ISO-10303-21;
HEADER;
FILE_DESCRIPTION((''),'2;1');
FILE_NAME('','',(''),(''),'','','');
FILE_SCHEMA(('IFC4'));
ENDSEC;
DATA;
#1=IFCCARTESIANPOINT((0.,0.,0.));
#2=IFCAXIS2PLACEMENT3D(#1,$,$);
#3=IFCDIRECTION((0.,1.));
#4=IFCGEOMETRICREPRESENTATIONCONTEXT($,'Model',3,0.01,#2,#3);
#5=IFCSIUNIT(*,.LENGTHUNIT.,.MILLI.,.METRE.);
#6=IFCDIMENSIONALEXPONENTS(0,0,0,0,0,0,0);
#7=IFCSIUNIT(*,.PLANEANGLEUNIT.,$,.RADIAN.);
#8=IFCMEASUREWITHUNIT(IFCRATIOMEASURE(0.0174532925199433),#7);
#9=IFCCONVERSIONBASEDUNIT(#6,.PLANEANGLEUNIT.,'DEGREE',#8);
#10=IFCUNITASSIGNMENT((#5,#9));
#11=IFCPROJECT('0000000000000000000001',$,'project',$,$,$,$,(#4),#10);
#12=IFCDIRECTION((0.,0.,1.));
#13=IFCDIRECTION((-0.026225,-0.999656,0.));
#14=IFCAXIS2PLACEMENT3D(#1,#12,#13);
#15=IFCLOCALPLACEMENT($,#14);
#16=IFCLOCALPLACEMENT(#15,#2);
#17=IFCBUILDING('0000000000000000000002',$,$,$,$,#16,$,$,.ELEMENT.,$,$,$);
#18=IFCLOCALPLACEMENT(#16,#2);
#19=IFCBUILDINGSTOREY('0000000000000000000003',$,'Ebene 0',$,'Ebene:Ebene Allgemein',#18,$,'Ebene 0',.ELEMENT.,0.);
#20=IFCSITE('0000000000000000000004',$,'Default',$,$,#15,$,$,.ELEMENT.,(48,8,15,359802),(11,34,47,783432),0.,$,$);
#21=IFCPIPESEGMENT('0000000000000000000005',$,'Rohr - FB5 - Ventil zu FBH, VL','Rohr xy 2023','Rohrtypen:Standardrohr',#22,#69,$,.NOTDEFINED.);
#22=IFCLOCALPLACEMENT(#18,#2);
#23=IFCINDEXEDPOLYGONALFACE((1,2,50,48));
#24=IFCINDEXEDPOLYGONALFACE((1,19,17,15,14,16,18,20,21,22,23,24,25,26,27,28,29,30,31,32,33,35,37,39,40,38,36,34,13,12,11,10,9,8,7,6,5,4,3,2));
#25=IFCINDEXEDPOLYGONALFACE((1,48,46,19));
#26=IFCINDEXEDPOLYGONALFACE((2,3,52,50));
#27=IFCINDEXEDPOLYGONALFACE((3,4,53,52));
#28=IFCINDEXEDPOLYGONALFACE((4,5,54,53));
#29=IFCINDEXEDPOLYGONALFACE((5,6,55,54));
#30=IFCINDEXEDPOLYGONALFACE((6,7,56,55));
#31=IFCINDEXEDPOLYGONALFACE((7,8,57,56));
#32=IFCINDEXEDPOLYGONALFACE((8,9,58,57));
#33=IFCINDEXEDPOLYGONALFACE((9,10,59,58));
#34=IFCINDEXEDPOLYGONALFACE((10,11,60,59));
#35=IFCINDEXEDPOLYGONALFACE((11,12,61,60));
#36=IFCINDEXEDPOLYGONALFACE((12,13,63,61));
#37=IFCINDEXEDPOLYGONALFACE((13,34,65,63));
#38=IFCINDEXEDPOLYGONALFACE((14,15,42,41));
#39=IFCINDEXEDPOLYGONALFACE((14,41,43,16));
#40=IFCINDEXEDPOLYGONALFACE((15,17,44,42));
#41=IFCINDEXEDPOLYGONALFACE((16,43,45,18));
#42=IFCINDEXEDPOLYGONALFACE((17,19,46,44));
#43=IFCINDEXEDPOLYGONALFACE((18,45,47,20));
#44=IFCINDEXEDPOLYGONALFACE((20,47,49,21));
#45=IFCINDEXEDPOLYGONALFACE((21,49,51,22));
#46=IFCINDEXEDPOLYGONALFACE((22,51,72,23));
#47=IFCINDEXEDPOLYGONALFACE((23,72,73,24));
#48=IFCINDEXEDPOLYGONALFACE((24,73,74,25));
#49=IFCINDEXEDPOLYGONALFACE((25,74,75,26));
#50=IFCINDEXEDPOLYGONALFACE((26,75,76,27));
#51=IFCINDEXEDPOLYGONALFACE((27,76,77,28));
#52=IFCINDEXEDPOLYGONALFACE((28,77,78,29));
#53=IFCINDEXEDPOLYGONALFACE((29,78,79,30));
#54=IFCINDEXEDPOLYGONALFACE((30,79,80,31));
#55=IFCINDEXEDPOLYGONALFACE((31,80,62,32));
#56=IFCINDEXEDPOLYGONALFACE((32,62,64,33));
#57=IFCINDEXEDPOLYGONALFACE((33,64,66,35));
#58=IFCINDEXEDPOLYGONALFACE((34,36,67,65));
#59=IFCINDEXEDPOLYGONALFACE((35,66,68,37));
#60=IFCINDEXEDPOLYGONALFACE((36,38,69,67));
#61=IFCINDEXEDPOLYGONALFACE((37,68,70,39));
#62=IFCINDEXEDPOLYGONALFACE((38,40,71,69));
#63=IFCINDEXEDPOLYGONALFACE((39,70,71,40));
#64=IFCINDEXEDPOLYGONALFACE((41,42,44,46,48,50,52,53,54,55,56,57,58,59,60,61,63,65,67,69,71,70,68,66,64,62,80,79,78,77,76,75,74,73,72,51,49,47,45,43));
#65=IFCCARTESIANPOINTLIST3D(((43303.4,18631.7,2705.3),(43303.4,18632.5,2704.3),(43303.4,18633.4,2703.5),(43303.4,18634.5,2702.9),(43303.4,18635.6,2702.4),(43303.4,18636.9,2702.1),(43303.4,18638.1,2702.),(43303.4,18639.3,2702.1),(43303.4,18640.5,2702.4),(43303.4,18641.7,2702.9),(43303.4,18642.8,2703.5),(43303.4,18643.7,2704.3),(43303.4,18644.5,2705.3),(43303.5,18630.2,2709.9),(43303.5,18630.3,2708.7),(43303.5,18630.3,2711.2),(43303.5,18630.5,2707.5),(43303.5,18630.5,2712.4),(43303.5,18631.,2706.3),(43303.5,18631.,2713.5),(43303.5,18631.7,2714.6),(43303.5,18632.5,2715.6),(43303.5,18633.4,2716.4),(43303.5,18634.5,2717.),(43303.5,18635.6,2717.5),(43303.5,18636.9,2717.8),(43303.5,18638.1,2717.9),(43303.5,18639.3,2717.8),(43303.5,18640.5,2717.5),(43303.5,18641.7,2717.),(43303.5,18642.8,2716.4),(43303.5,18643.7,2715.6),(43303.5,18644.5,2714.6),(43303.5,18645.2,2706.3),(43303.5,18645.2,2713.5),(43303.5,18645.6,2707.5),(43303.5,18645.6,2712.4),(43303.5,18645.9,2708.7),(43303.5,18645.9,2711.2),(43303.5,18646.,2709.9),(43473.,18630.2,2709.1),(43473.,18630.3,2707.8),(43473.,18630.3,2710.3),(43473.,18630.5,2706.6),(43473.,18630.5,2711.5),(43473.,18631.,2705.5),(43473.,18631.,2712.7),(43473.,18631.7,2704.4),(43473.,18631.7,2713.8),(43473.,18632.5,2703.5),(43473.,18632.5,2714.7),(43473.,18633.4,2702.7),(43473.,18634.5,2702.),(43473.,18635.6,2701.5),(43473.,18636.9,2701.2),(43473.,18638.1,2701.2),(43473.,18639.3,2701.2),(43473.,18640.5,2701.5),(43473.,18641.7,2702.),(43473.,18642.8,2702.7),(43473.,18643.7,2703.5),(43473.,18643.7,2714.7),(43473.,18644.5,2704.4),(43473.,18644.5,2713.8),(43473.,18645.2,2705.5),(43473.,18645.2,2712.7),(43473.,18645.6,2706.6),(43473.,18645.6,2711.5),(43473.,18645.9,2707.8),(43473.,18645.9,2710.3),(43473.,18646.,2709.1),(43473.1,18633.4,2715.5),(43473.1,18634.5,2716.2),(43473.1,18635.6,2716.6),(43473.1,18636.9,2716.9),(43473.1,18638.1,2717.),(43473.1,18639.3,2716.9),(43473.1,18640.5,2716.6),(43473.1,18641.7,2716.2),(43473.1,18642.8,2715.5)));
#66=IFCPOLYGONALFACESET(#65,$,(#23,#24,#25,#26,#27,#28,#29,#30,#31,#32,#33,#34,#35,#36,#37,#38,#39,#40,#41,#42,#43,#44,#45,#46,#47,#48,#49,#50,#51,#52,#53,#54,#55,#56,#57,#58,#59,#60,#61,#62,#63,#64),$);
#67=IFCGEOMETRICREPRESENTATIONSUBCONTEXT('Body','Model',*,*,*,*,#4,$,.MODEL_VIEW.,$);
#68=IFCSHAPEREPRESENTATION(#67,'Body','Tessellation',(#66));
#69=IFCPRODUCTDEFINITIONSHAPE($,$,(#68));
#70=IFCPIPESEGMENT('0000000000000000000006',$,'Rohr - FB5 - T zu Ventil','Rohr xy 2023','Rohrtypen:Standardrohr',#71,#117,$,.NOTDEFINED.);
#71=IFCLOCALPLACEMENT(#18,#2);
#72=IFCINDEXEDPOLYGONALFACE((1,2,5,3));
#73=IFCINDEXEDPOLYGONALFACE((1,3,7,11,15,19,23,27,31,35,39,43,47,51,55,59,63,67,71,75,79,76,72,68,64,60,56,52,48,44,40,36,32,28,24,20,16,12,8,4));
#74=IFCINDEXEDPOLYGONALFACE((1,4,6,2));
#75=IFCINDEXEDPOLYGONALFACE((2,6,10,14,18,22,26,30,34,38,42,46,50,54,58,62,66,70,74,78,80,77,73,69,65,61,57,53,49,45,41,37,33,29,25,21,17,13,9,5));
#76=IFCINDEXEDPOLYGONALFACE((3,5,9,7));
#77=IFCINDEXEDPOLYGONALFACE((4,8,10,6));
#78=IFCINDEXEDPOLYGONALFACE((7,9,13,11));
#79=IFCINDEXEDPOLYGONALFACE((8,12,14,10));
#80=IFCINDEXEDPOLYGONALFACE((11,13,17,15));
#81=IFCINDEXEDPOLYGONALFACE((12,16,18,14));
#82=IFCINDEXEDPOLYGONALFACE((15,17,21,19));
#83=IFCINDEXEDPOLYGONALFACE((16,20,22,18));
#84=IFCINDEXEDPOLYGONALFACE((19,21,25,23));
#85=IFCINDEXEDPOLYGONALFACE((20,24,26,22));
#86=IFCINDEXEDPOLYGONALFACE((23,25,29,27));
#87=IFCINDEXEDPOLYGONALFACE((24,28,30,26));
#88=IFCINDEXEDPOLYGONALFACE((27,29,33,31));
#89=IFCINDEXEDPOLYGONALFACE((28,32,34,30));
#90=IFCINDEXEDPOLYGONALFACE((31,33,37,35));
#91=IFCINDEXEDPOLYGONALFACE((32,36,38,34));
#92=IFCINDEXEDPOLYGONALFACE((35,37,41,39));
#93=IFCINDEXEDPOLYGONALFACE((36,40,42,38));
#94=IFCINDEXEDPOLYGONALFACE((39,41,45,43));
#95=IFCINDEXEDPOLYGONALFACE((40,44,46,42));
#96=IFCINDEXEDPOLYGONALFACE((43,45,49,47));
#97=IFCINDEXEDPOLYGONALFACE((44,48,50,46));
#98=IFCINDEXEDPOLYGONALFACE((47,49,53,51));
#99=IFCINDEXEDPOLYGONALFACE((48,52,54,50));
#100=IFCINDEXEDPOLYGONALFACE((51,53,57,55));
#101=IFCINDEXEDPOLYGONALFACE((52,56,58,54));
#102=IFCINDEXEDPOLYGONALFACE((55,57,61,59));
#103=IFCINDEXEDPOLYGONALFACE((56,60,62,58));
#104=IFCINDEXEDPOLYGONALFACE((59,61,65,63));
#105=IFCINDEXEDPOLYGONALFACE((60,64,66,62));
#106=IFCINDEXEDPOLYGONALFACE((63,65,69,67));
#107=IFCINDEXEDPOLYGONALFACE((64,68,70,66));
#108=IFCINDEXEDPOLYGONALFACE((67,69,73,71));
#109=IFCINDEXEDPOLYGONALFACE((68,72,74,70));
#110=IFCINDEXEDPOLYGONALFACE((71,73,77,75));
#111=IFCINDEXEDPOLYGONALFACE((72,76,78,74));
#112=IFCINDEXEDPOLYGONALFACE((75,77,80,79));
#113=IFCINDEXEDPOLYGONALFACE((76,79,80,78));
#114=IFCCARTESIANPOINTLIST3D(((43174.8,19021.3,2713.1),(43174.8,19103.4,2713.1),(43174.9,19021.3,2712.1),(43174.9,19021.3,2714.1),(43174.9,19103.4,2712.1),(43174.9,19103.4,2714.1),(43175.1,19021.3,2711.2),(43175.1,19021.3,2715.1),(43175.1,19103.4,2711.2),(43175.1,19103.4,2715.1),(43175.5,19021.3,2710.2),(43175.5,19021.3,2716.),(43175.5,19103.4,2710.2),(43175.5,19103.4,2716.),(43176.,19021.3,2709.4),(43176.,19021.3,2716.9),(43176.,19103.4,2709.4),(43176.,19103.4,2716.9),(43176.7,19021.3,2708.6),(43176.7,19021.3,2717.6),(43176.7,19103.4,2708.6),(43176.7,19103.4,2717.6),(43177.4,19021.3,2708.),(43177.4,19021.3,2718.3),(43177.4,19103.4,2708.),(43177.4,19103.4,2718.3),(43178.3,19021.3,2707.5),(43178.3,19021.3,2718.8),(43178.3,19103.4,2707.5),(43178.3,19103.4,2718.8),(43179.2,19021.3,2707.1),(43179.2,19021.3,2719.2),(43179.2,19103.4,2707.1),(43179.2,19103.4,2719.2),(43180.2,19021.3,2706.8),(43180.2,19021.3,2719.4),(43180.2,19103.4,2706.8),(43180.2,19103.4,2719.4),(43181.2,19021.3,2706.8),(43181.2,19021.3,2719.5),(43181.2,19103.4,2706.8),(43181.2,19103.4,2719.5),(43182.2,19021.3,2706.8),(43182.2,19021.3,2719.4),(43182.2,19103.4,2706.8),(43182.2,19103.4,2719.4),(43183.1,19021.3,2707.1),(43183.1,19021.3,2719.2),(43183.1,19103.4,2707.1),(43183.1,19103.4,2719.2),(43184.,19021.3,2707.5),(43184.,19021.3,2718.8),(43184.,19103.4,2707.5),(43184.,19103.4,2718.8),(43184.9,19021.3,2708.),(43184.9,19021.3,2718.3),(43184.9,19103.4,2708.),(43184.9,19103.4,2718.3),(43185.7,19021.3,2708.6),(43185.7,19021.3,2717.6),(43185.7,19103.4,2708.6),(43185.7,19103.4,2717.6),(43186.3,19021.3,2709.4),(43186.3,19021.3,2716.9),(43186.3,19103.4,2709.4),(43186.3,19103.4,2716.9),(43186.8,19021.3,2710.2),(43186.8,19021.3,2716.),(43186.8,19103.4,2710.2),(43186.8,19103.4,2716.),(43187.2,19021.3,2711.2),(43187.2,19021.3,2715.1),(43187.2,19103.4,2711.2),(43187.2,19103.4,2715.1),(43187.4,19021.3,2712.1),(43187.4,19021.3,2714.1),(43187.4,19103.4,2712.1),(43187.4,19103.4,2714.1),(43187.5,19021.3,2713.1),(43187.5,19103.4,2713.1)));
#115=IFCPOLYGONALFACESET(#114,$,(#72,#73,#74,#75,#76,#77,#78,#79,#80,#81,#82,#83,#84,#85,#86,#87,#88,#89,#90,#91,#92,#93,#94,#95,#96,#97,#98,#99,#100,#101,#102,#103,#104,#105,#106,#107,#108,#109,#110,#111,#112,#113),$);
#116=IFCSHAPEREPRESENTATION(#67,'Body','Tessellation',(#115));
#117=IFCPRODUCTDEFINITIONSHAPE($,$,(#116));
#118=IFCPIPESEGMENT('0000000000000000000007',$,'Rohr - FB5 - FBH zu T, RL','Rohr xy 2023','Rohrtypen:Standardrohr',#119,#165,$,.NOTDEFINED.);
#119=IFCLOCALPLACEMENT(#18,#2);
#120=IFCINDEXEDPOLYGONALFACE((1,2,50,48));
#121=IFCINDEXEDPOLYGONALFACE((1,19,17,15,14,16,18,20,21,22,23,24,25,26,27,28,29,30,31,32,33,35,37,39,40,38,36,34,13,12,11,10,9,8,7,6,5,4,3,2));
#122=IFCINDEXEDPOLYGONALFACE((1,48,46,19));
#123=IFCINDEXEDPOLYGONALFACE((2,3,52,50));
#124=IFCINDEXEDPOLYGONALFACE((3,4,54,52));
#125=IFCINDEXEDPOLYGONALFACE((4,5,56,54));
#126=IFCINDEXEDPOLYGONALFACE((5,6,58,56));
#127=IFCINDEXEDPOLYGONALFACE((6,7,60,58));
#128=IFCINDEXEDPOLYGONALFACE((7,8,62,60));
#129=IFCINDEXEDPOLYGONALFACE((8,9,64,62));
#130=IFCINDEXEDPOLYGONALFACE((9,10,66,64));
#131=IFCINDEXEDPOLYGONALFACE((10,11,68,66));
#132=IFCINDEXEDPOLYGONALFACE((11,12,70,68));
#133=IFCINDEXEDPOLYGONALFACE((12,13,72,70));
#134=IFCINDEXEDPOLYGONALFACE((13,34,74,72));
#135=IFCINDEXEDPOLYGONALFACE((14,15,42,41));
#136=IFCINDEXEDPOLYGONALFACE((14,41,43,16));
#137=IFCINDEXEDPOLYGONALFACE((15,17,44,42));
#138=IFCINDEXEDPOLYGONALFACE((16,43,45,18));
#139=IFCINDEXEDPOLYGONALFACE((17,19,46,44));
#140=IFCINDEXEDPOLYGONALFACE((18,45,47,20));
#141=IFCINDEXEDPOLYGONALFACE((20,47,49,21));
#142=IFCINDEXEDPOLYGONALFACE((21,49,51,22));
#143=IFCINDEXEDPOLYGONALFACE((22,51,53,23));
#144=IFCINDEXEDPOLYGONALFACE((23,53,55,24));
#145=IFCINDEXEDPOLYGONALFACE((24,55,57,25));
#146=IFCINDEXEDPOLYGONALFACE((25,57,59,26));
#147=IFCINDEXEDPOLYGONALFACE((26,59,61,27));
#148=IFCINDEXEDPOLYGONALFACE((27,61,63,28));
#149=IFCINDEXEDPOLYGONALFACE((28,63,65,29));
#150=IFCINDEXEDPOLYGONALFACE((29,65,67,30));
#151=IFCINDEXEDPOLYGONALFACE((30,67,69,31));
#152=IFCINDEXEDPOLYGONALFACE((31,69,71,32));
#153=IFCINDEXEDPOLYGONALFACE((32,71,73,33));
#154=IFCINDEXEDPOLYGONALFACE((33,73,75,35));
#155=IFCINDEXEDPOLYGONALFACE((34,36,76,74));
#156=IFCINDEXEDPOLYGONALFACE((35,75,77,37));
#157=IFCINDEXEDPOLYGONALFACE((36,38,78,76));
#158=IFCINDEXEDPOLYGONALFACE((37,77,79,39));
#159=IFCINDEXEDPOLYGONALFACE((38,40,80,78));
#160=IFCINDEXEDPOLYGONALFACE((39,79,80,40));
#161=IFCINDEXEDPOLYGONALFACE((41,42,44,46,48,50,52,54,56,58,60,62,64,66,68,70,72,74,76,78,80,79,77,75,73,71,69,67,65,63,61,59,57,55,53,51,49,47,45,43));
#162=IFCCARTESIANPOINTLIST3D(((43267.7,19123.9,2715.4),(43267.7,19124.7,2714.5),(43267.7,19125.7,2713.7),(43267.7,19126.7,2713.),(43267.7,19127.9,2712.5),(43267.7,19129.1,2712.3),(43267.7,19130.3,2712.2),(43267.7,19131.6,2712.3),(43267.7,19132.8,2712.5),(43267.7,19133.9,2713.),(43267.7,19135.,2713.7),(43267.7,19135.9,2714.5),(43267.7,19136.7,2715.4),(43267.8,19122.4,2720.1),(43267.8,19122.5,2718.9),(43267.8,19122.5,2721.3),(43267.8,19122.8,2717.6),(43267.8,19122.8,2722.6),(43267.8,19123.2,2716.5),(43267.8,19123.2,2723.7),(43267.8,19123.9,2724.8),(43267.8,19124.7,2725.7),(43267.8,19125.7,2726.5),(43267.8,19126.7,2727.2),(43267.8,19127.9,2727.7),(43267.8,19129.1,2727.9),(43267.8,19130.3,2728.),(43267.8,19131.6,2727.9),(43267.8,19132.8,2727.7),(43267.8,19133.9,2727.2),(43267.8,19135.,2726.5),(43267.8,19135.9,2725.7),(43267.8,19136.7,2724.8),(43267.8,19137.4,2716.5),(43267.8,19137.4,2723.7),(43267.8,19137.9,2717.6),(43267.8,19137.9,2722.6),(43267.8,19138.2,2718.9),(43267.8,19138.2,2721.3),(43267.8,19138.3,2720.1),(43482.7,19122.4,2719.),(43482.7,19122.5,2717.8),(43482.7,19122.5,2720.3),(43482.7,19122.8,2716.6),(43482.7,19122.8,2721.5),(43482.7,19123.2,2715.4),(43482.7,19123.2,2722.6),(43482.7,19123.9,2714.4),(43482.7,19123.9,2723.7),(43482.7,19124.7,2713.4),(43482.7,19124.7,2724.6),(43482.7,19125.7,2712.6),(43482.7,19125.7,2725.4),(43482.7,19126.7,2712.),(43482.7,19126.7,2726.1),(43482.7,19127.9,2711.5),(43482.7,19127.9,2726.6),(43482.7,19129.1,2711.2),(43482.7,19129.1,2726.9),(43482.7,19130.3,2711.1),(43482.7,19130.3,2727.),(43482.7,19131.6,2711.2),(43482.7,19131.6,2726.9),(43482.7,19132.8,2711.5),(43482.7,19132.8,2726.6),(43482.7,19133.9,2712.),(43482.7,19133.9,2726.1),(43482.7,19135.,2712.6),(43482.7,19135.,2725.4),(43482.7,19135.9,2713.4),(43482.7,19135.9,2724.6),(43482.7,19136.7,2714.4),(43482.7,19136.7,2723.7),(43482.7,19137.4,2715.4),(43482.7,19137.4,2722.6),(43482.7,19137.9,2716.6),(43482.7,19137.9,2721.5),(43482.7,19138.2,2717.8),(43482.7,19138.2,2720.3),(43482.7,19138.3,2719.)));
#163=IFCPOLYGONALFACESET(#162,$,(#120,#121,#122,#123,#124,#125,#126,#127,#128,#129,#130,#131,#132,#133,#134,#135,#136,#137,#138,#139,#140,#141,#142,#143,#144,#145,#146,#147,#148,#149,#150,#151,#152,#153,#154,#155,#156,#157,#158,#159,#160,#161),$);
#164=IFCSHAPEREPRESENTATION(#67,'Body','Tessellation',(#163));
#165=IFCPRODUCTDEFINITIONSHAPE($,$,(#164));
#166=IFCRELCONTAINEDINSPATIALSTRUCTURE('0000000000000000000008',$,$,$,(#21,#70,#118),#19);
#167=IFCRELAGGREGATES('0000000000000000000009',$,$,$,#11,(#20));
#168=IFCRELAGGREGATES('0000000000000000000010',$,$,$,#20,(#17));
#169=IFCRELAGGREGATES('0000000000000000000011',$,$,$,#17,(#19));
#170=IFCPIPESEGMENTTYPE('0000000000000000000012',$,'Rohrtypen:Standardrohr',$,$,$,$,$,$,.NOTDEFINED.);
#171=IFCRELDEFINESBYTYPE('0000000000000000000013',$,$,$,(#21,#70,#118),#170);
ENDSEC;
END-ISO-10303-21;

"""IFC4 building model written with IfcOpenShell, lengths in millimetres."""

from ifc_helpers import new_model, entity, si_unit, converted_unit, direction, frame, origin, place, context, subcontext, project, spatial, indexed_curve, outline, extrude, type_object, element, save


model = new_model("IFC4")

# Units and contexts
model_context = context("Model", 3, precision=0.01, world=origin(), true_north=direction((0.0, 1.0)))
body_context = subcontext(model_context, "Body", "Model", "MODEL_VIEW")
ifc_project = project(units=[si_unit("LENGTHUNIT", "METRE", prefix="MILLI"), converted_unit("PLANEANGLEUNIT", "DEGREE", entity("IfcRatioMeasure", 0.0174532925199433), si_unit("PLANEANGLEUNIT", "RADIAN"), dimensions=[0, 0, 0, 0, 0, 0, 0])], contexts=[model_context])

# Site, building, storey
site_placement = place(None, frame((0.0, 0.0, 0.0), z_axis=(0.0, 0.0, 1.0), x_axis=(-0.026225, -0.999656, 0.0)))
site = spatial("IfcSite", under=ifc_project, at=site_placement, Name="Default", CompositionType="ELEMENT", RefLatitude=(48, 8, 15, 359802), RefLongitude=(11, 34, 47, 783432), RefElevation=0.0)
building_placement = place(site_placement, origin())
building = spatial("IfcBuilding", under=site, at=building_placement, CompositionType="ELEMENT")
storey_placement = place(building_placement, origin())
storey = spatial("IfcBuildingStorey", under=building, at=storey_placement, Name="Ebene 0", ObjectType="Ebene:Ebene Allgemein", LongName="Ebene 0", CompositionType="ELEMENT", Elevation=0.0)

# Pipe segments
pipe_segment_type = type_object("IfcPipeSegmentType", Name="Rohrtypen:Standardrohr", PredefinedType="NOTDEFINED")
pipe_segment_1_placement = place(storey_placement, origin())
element("IfcPipeSegment", 1, at=pipe_segment_1_placement, inside=storey, type_object=pipe_segment_type, Name="Rohr - FB5 - Ventil zu FBH, VL", Description="Rohr xy 2023", ObjectType="Rohrtypen:Standardrohr", PredefinedType="NOTDEFINED", context=body_context, shape_type="SweptSolid", body=[
    extrude(outline(indexed_curve([(7.9, 0.0), (7.8, 1.2), (7.6, 2.5), (7.1, 3.6), (6.4, 4.7), (5.6, 5.6), (4.7, 6.4), (3.6, 7.1), (2.5, 7.6), (1.2, 7.8), (0.0, 7.9), (-1.2, 7.8), (-2.5, 7.6), (-3.6, 7.1), (-4.7, 6.4), (-5.6, 5.6), (-6.4, 4.7), (-7.1, 3.6), (-7.6, 2.5), (-7.8, 1.2), (-7.9, 0.0), (-7.8, -1.2), (-7.6, -2.5), (-7.1, -3.6), (-6.4, -4.7), (-5.6, -5.6), (-4.7, -6.4), (-3.6, -7.1), (-2.5, -7.6), (-1.2, -7.8), (0.0, -7.9), (1.2, -7.8), (2.5, -7.6), (3.6, -7.1), (4.7, -6.4), (5.6, -5.6), (6.4, -4.7), (7.1, -3.6), (7.6, -2.5), (7.8, -1.2), (7.9, 0.0)], self_intersect=False)), frame((43303.5, 18638.1, 2709.9), z_axis=(0.999988, 0.0, -0.005), x_axis=(0.0, 1.0, 0.0)), (0.0, 0.0, 1.0), 169.5),
])
pipe_segment_2_placement = place(storey_placement, origin())
element("IfcPipeSegment", 2, at=pipe_segment_2_placement, inside=storey, type_object=pipe_segment_type, Name="Rohr - FB5 - T zu Ventil", Description="Rohr xy 2023", ObjectType="Rohrtypen:Standardrohr", PredefinedType="NOTDEFINED", context=body_context, shape_type="SweptSolid", body=[
    extrude(outline(indexed_curve([(6.4, 0.0), (6.3, 1.0), (6.0, 2.0), (5.7, 2.9), (5.1, 3.7), (4.5, 4.5), (3.7, 5.1), (2.9, 5.7), (2.0, 6.0), (1.0, 6.3), (0.0, 6.4), (-1.0, 6.3), (-2.0, 6.0), (-2.9, 5.7), (-3.7, 5.1), (-4.5, 4.5), (-5.1, 3.7), (-5.7, 2.9), (-6.0, 2.0), (-6.3, 1.0), (-6.4, 0.0), (-6.3, -1.0), (-6.0, -2.0), (-5.7, -2.9), (-5.1, -3.7), (-4.5, -4.5), (-3.7, -5.1), (-2.9, -5.7), (-2.0, -6.0), (-1.0, -6.3), (0.0, -6.4), (1.0, -6.3), (2.0, -6.0), (2.9, -5.7), (3.7, -5.1), (4.5, -4.5), (5.1, -3.7), (5.7, -2.9), (6.0, -2.0), (6.3, -1.0), (6.4, 0.0)], self_intersect=False)), frame((43181.2, 19021.3, 2713.1), z_axis=(0.0, 1.0, 0.0), x_axis=(-1.0, 0.0, 0.0)), (0.0, 0.0, 1.0), 82.2),
])
pipe_segment_3_placement = place(storey_placement, origin())
element("IfcPipeSegment", 3, at=pipe_segment_3_placement, inside=storey, type_object=pipe_segment_type, Name="Rohr - FB5 - FBH zu T, RL", Description="Rohr xy 2023", ObjectType="Rohrtypen:Standardrohr", PredefinedType="NOTDEFINED", context=body_context, shape_type="SweptSolid", body=[
    extrude(outline(indexed_curve([(7.9, 0.0), (7.8, 1.2), (7.6, 2.5), (7.1, 3.6), (6.4, 4.7), (5.6, 5.6), (4.7, 6.4), (3.6, 7.1), (2.5, 7.6), (1.2, 7.8), (0.0, 7.9), (-1.2, 7.8), (-2.5, 7.6), (-3.6, 7.1), (-4.7, 6.4), (-5.6, 5.6), (-6.4, 4.7), (-7.1, 3.6), (-7.6, 2.5), (-7.8, 1.2), (-7.9, 0.0), (-7.8, -1.2), (-7.6, -2.5), (-7.1, -3.6), (-6.4, -4.7), (-5.6, -5.6), (-4.7, -6.4), (-3.6, -7.1), (-2.5, -7.6), (-1.2, -7.8), (0.0, -7.9), (1.2, -7.8), (2.5, -7.6), (3.6, -7.1), (4.7, -6.4), (5.6, -5.6), (6.4, -4.7), (7.1, -3.6), (7.6, -2.5), (7.8, -1.2), (7.9, 0.0)], self_intersect=False)), frame((43482.7, 19130.3, 2719.0), z_axis=(-0.999988, 0.0, 0.005), x_axis=(0.0, 1.0, 0.0)), (0.0, 0.0, 1.0), 214.9),
])

save(model, "model.ifc")
